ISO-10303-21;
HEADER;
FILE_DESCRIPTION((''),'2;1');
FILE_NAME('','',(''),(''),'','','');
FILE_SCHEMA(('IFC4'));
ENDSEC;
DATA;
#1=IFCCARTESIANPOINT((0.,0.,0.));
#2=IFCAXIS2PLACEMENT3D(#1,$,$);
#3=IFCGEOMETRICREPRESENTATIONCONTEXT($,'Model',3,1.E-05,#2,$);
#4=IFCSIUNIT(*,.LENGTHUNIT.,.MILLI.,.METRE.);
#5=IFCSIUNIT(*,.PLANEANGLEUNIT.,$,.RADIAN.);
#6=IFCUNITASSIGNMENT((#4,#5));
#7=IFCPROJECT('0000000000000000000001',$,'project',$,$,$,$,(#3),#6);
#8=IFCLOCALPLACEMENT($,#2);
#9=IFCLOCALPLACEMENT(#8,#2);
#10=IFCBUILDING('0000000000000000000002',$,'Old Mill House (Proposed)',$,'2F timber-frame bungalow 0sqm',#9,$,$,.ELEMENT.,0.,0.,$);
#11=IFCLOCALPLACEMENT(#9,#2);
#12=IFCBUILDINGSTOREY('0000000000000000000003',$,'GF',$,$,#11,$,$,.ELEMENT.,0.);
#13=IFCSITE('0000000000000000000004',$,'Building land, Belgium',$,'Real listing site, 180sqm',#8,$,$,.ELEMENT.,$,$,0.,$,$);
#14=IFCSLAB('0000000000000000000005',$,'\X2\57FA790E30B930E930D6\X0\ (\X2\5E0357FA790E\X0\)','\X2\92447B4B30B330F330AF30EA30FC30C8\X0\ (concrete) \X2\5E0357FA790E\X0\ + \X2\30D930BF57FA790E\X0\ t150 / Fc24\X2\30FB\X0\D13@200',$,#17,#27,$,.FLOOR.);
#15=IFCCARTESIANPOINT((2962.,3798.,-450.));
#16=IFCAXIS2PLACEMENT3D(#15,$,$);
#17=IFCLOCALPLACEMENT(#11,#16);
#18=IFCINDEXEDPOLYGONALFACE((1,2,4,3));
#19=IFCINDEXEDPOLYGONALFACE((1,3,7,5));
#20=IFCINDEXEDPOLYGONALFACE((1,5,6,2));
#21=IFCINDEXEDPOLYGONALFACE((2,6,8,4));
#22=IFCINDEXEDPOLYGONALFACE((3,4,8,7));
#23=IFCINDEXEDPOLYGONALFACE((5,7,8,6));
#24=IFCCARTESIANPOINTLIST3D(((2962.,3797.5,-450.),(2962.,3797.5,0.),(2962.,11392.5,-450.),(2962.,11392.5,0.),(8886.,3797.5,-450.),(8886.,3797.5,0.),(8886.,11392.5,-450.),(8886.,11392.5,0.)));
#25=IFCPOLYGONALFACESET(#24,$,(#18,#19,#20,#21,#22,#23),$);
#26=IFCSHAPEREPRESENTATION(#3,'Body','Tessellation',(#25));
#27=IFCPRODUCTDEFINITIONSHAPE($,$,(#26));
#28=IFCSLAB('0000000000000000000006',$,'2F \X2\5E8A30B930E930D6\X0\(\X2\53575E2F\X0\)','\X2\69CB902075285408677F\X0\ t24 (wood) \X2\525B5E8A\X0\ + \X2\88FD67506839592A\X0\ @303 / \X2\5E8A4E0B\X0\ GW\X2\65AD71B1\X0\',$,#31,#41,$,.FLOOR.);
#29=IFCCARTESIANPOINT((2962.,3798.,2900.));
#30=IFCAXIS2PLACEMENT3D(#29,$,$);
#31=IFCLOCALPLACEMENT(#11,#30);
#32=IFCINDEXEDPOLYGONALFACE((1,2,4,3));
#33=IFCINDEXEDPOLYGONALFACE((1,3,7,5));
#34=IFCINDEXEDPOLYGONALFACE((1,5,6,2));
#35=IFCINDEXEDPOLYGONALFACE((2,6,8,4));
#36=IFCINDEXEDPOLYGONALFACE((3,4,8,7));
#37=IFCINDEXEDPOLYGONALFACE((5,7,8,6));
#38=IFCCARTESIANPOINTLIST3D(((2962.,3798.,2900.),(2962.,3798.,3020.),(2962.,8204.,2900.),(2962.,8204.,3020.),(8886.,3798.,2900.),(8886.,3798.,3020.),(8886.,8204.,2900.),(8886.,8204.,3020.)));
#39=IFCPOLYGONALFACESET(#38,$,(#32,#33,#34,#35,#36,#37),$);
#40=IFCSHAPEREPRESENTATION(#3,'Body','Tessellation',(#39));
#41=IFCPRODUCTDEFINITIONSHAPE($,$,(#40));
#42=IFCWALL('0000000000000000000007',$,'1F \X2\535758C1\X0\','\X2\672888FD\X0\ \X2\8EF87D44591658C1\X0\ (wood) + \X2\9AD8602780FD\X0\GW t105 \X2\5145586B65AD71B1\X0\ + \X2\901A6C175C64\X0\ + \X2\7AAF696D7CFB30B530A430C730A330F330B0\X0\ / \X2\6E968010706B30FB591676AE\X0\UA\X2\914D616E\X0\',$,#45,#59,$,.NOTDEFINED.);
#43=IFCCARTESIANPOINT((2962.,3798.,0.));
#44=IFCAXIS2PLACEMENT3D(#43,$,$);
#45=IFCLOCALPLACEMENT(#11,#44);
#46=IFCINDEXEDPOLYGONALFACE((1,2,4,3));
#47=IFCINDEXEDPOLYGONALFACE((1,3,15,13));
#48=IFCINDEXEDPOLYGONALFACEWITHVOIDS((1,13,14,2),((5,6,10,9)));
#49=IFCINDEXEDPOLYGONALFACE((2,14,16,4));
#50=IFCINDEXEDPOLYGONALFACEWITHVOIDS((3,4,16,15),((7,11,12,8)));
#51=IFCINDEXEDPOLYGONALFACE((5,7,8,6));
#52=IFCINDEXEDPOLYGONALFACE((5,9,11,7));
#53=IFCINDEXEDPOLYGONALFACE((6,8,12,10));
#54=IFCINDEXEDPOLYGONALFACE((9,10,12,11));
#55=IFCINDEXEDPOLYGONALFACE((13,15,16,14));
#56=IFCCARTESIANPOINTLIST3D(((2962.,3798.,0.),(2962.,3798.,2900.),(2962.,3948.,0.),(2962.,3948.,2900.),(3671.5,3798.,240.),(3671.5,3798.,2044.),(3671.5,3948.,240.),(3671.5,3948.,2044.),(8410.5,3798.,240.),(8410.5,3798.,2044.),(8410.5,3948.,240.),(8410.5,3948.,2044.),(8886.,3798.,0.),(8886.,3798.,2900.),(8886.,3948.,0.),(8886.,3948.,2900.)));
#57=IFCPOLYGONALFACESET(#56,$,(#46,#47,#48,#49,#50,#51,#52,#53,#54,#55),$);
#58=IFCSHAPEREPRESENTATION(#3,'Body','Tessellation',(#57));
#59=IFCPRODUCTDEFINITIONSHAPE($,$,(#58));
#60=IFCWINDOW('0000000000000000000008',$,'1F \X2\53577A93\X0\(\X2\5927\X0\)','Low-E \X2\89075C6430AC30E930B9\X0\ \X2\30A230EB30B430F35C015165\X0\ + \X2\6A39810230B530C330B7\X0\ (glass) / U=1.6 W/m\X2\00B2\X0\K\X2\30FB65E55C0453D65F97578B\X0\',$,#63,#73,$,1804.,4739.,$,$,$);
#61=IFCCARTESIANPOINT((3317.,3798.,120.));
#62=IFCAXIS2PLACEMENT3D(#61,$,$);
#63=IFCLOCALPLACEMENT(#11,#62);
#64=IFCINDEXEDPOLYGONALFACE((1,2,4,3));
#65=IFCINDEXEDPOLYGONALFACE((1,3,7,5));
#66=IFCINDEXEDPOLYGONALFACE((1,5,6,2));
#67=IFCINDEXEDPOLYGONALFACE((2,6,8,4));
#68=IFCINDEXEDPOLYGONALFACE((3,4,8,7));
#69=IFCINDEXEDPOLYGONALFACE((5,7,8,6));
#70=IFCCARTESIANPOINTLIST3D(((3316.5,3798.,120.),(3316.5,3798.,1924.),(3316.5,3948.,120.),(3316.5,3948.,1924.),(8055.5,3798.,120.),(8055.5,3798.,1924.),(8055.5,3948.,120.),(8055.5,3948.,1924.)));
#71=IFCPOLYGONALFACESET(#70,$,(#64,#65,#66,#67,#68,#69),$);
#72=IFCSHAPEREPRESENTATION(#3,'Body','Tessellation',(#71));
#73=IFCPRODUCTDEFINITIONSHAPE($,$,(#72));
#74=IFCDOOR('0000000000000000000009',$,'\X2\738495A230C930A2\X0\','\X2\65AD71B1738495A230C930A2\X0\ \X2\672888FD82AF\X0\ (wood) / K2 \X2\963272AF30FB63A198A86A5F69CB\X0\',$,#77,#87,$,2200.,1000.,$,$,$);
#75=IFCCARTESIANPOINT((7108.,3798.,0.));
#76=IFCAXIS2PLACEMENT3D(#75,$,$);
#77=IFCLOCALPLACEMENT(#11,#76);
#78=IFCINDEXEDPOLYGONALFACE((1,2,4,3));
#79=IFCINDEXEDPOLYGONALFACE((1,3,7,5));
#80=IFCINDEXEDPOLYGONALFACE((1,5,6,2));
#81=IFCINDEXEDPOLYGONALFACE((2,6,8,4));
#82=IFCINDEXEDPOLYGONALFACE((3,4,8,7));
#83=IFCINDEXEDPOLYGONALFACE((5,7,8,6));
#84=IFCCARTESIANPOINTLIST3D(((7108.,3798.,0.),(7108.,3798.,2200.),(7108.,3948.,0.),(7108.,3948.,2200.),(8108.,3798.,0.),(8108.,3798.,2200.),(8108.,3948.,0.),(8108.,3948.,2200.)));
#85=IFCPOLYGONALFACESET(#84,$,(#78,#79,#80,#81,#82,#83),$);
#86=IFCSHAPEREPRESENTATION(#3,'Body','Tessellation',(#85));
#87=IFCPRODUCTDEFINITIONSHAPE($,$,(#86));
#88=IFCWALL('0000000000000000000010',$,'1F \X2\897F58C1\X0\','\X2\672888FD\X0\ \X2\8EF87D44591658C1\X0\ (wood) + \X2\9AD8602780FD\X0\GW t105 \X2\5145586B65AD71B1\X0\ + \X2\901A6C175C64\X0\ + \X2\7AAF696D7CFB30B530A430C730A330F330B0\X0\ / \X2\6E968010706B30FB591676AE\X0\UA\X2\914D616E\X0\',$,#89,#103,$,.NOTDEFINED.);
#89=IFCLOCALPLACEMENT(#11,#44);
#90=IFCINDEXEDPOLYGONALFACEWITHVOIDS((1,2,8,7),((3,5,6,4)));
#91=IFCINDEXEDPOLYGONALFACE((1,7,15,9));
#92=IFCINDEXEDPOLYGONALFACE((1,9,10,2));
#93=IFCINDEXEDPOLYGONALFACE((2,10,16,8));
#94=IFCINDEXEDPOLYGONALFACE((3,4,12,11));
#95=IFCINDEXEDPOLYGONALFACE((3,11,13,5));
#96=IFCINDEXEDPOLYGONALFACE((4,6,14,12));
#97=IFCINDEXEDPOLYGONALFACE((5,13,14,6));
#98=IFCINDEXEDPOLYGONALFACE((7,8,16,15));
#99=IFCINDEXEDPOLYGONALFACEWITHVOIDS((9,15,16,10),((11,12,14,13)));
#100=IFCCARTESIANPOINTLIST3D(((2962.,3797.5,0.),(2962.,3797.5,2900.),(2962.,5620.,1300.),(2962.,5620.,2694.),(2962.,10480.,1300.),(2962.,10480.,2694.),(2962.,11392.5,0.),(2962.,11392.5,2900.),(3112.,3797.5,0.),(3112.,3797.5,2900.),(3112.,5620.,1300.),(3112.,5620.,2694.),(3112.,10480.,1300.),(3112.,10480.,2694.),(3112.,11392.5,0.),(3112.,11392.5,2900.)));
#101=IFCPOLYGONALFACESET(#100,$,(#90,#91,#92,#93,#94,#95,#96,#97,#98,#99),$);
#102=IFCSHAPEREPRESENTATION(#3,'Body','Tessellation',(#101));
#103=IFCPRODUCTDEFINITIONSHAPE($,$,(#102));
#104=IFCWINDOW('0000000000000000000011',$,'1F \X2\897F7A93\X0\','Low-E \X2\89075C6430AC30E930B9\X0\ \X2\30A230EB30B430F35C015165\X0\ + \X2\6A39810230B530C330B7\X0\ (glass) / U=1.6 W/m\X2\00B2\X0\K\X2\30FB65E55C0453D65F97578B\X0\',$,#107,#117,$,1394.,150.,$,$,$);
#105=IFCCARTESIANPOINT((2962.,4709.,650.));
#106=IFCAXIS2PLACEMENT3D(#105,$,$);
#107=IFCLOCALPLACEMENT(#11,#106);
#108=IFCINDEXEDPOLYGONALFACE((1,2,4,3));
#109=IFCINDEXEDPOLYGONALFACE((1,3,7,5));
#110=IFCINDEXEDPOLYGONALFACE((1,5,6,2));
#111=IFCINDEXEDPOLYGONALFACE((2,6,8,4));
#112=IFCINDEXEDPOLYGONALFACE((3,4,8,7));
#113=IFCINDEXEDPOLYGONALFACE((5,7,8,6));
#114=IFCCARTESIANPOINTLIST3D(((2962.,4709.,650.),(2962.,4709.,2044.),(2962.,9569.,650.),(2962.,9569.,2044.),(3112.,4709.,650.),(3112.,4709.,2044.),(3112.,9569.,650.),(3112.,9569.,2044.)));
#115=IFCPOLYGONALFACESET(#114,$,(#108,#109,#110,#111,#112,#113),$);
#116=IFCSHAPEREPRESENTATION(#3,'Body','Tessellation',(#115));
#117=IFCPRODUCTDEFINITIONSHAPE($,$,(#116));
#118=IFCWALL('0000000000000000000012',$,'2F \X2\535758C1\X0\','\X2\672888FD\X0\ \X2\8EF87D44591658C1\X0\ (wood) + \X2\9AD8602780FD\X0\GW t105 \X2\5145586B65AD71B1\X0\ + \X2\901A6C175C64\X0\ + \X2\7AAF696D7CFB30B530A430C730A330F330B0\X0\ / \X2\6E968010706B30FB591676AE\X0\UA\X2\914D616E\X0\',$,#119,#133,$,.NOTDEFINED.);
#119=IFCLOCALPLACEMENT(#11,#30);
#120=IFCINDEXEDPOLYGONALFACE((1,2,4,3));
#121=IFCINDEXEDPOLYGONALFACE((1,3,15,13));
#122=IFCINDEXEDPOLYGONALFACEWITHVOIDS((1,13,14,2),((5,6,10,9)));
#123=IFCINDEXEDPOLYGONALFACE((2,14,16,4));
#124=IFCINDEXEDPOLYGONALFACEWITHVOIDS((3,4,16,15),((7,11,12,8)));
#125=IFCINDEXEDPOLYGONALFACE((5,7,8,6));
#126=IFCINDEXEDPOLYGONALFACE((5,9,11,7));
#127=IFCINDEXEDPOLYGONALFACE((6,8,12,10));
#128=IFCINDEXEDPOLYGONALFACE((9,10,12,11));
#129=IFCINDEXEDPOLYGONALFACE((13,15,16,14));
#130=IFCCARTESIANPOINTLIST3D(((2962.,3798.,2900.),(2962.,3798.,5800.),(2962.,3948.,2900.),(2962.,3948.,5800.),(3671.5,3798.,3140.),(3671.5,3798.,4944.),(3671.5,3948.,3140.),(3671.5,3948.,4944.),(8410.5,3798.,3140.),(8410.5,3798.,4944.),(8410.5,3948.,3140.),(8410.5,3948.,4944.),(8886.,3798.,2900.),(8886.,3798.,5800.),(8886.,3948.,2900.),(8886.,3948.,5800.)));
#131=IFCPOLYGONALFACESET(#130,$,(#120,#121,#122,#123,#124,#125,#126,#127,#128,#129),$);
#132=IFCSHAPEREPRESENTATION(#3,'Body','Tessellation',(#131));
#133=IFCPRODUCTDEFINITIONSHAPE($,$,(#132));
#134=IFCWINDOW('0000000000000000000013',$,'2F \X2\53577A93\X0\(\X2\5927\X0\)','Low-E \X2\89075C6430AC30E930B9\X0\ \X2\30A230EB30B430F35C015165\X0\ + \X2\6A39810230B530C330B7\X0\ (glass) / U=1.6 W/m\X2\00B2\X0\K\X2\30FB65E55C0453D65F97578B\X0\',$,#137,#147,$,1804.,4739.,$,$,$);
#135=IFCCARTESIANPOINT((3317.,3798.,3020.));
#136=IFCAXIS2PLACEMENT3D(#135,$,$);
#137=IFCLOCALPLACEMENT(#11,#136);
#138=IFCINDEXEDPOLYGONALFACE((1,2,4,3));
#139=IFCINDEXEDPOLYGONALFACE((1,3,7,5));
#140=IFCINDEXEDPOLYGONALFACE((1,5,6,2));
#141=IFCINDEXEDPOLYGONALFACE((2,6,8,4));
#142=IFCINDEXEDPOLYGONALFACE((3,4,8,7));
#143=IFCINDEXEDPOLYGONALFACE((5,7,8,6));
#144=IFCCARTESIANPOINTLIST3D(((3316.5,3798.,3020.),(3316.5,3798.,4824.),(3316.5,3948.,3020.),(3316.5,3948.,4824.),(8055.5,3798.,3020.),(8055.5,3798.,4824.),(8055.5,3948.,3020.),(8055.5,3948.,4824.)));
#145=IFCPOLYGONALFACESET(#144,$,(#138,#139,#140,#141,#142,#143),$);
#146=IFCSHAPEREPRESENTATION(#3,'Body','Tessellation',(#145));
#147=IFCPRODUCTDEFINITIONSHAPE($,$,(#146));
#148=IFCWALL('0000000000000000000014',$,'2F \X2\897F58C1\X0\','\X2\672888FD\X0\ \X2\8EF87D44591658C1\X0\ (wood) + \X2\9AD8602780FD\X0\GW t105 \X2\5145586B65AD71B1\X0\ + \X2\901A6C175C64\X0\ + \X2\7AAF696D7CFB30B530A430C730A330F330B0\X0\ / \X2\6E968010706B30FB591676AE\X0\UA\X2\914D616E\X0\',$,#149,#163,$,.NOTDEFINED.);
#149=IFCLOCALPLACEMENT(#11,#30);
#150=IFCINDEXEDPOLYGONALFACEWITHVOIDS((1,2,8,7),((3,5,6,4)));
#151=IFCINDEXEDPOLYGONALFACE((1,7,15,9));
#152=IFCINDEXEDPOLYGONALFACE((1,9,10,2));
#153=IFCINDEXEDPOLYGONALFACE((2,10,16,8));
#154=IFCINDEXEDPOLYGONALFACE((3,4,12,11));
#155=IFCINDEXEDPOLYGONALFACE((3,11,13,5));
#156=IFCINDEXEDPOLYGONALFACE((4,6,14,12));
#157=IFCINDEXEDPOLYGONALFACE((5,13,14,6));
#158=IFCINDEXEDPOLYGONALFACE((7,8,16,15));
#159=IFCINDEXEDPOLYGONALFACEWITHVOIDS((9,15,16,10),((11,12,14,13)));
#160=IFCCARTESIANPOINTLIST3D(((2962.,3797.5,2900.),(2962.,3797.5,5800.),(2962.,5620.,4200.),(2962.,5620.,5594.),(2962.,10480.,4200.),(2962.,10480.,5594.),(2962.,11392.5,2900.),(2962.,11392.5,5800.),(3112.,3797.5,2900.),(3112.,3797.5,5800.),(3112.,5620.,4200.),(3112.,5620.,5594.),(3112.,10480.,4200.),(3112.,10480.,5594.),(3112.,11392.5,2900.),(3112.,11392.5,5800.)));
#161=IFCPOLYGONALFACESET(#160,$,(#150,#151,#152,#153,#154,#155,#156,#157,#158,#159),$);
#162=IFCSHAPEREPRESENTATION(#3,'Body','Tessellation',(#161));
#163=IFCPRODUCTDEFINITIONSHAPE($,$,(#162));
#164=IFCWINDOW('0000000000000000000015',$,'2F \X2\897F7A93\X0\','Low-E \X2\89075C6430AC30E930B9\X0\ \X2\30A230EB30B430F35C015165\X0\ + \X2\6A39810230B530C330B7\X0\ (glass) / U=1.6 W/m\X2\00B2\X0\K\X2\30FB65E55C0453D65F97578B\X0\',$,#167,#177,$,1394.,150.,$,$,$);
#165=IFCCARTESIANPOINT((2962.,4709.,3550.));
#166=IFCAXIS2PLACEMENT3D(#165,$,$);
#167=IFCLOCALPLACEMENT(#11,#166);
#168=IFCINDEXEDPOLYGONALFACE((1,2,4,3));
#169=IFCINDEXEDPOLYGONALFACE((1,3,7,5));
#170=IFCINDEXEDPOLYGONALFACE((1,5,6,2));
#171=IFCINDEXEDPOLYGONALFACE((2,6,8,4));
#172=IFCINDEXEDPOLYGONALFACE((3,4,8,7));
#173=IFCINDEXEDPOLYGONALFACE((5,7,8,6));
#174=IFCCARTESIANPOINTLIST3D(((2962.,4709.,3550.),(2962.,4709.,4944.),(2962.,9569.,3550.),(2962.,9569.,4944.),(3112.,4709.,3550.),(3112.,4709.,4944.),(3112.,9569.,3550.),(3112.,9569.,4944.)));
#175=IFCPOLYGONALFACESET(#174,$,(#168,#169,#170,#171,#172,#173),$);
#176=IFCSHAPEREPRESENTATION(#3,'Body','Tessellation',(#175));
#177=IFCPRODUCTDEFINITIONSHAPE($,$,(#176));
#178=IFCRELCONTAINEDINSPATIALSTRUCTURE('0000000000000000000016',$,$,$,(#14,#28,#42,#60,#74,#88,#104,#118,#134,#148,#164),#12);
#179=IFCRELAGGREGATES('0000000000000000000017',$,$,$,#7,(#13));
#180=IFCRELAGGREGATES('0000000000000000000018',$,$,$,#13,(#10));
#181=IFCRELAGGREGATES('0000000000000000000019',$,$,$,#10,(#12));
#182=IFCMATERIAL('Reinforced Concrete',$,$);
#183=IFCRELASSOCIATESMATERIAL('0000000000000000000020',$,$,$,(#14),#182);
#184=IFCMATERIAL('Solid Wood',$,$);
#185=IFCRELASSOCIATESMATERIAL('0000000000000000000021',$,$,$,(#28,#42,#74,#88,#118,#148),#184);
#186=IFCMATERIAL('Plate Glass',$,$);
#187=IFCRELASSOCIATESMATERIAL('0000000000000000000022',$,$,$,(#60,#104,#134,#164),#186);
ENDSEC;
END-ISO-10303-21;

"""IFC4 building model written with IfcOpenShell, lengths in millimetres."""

from ifc_helpers import new_model, si_unit, frame, frame_2d, origin, place, context, project, spatial, rectangle, extrude, material, element, fill, save


model = new_model("IFC4")

# Units and contexts
model_context = context("Model", 3, precision=1e-05, world=origin())
ifc_project = project(units=[si_unit("LENGTHUNIT", "METRE", prefix="MILLI"), si_unit("PLANEANGLEUNIT", "RADIAN")], contexts=[model_context])

# Site, building, storey
site_placement = place(None, origin())
site = spatial("IfcSite", under=ifc_project, at=site_placement, Name="Building land, Belgium", ObjectType="Real listing site, 180sqm", CompositionType="ELEMENT", RefElevation=0.0)
building_placement = place(site_placement, origin())
building = spatial("IfcBuilding", under=site, at=building_placement, Name="Old Mill House (Proposed)", ObjectType="2F timber-frame bungalow 0sqm", CompositionType="ELEMENT", ElevationOfRefHeight=0.0, ElevationOfTerrain=0.0)
storey_placement = place(building_placement, origin())
storey = spatial("IfcBuildingStorey", under=building, at=storey_placement, Name="GF", CompositionType="ELEMENT", Elevation=0.0)

# Slabs
ifc_material_1 = material(Name="Reinforced Concrete")
slab_1_placement = place(storey_placement, frame((2962.0, 3798.0, -450.0)))
element("IfcSlab", 1, at=slab_1_placement, inside=storey, material=ifc_material_1, Name="基礎スラブ (布基礎)", Description="鉄筋コンクリート (concrete) 布基礎 + ベタ基礎 t150 / Fc24・D13@200", PredefinedType="FLOOR", context=model_context, shape_type="SweptSolid", body=[
    extrude(rectangle(XDim=5924.0, YDim=7595.0, at=frame_2d((2962.0, 3797.0))), frame((2962.0, 3798.0, -450.0)), (0.0, 0.0, 1.0), 450.0),
])
ifc_material_2 = material(Name="Solid Wood")
slab_2_placement = place(storey_placement, frame((2962.0, 3798.0, 2900.0)))
element("IfcSlab", 2, at=slab_2_placement, inside=storey, material=ifc_material_2, Name="2F 床スラブ(南帯)", Description="構造用合板 t24 (wood) 剛床 + 製材根太 @303 / 床下 GW断熱", PredefinedType="FLOOR", context=model_context, shape_type="SweptSolid", body=[
    extrude(rectangle(XDim=5924.0, YDim=4406.0, at=frame_2d((2962.0, 2203.0))), frame((2962.0, 3798.0, 2900.0)), (0.0, 0.0, 1.0), 120.0),
])

# Wall, openings, window, door
wall_1_placement = place(storey_placement, frame((2962.0, 3798.0, 0.0)))
wall_1 = element("IfcWall", 3, at=wall_1_placement, inside=storey, material=ifc_material_2, Name="1F 南壁", Description="木製 軸組外壁 (wood) + 高性能GW t105 充填断熱 + 通気層 + 窯業系サイディング / 準耐火・外皮UA配慮", PredefinedType="NOTDEFINED", context=model_context, shape_type="SweptSolid", body=[
    extrude(rectangle(XDim=5924.0, YDim=150.0, at=frame_2d((2962.0, 75.0))), frame((2962.0, 3798.0, 0.0)), (0.0, 0.0, 1.0), 2900.0),
])
opening_1_placement = place(storey_placement, frame((3317.0, 3798.0, 120.0)))
opening_1 = element("IfcOpeningElement", 4, at=opening_1_placement, cuts=wall_1, PredefinedType="NOTDEFINED", context=model_context, shape_type="SweptSolid", body=[
    extrude(rectangle(XDim=4739.0, YDim=150.0, at=frame_2d((2369.0, 75.0))), frame((3317.0, 3798.0, 120.0)), (0.0, 0.0, 1.0), 1804.0),
])
opening_2_placement = place(storey_placement, frame((7108.0, 3798.0, 0.0)))
opening_2 = element("IfcOpeningElement", 5, at=opening_2_placement, cuts=wall_1, PredefinedType="NOTDEFINED", context=model_context, shape_type="SweptSolid", body=[
    extrude(rectangle(XDim=1000.0, YDim=150.0, at=frame_2d((500.0, 75.0))), frame((7108.0, 3798.0, 0.0)), (0.0, 0.0, 1.0), 2200.0),
])
ifc_material_3 = material(Name="Plate Glass")
window_1_placement = place(storey_placement, frame((3317.0, 3798.0, 120.0)))
window_1 = element("IfcWindow", 6, at=window_1_placement, inside=storey, material=ifc_material_3, Name="1F 南窓(大)", Description="Low-E 複層ガラス アルゴン封入 + 樹脂サッシ (glass) / U=1.6 W/m²K・日射取得型", OverallHeight=1804.0, OverallWidth=4739.0, context=model_context, shape_type="SweptSolid", body=[
    extrude(rectangle(XDim=4739.0, YDim=150.0, at=frame_2d((2369.0, 75.0))), frame((3317.0, 3798.0, 120.0)), (0.0, 0.0, 1.0), 1804.0),
])
fill(opening_1, window_1)
door_placement = place(storey_placement, frame((7108.0, 3798.0, 0.0)))
door = element("IfcDoor", 7, at=door_placement, inside=storey, material=ifc_material_2, Name="玄関ドア", Description="断熱玄関ドア 木製芯 (wood) / K2 防犯・採風機構", OverallHeight=2200.0, OverallWidth=1000.0, context=model_context, shape_type="SweptSolid", body=[
    extrude(rectangle(XDim=1000.0, YDim=150.0, at=frame_2d((500.0, 75.0))), frame((7108.0, 3798.0, 0.0)), (0.0, 0.0, 1.0), 2200.0),
])
fill(opening_2, door)

# Wall, opening, window
wall_2_placement = place(storey_placement, frame((2962.0, 3798.0, 0.0)))
wall_2 = element("IfcWall", 8, at=wall_2_placement, inside=storey, material=ifc_material_2, Name="1F 西壁", Description="木製 軸組外壁 (wood) + 高性能GW t105 充填断熱 + 通気層 + 窯業系サイディング / 準耐火・外皮UA配慮", PredefinedType="NOTDEFINED", context=model_context, shape_type="SweptSolid", body=[
    extrude(rectangle(XDim=150.0, YDim=7595.0, at=frame_2d((75.0, 3797.0))), frame((2962.0, 3798.0, 0.0)), (0.0, 0.0, 1.0), 2900.0),
])
opening_3_placement = place(storey_placement, frame((2962.0, 4709.0, 650.0)))
opening_3 = element("IfcOpeningElement", 9, at=opening_3_placement, cuts=wall_2, PredefinedType="NOTDEFINED", context=model_context, shape_type="SweptSolid", body=[
    extrude(rectangle(XDim=150.0, YDim=4860.0, at=frame_2d((75.0, 2430.0))), frame((2962.0, 4709.0, 650.0)), (0.0, 0.0, 1.0), 1394.0),
])
window_2_placement = place(storey_placement, frame((2962.0, 4709.0, 650.0)))
window_2 = element("IfcWindow", 10, at=window_2_placement, inside=storey, material=ifc_material_3, Name="1F 西窓", Description="Low-E 複層ガラス アルゴン封入 + 樹脂サッシ (glass) / U=1.6 W/m²K・日射取得型", OverallHeight=1394.0, OverallWidth=150.0, context=model_context, shape_type="SweptSolid", body=[
    extrude(rectangle(XDim=150.0, YDim=4860.0, at=frame_2d((75.0, 2430.0))), frame((2962.0, 4709.0, 650.0)), (0.0, 0.0, 1.0), 1394.0),
])
fill(opening_3, window_2)

# Walls, openings, windows
wall_3_placement = place(storey_placement, frame((2962.0, 3798.0, 2900.0)))
wall_3 = element("IfcWall", 11, at=wall_3_placement, inside=storey, material=ifc_material_2, Name="2F 南壁", Description="木製 軸組外壁 (wood) + 高性能GW t105 充填断熱 + 通気層 + 窯業系サイディング / 準耐火・外皮UA配慮", PredefinedType="NOTDEFINED", context=model_context, shape_type="SweptSolid", body=[
    extrude(rectangle(XDim=5924.0, YDim=150.0, at=frame_2d((2962.0, 75.0))), frame((2962.0, 3798.0, 2900.0)), (0.0, 0.0, 1.0), 2900.0),
])
opening_4_placement = place(storey_placement, frame((3317.0, 3798.0, 3020.0)))
opening_4 = element("IfcOpeningElement", 12, at=opening_4_placement, cuts=wall_3, PredefinedType="NOTDEFINED", context=model_context, shape_type="SweptSolid", body=[
    extrude(rectangle(XDim=4739.0, YDim=150.0, at=frame_2d((2369.0, 75.0))), frame((3317.0, 3798.0, 3020.0)), (0.0, 0.0, 1.0), 1804.0),
])
window_3_placement = place(storey_placement, frame((3317.0, 3798.0, 3020.0)))
window_3 = element("IfcWindow", 13, at=window_3_placement, inside=storey, material=ifc_material_3, Name="2F 南窓(大)", Description="Low-E 複層ガラス アルゴン封入 + 樹脂サッシ (glass) / U=1.6 W/m²K・日射取得型", OverallHeight=1804.0, OverallWidth=4739.0, context=model_context, shape_type="SweptSolid", body=[
    extrude(rectangle(XDim=4739.0, YDim=150.0, at=frame_2d((2369.0, 75.0))), frame((3317.0, 3798.0, 3020.0)), (0.0, 0.0, 1.0), 1804.0),
])
fill(opening_4, window_3)
wall_4_placement = place(storey_placement, frame((2962.0, 3798.0, 2900.0)))
wall_4 = element("IfcWall", 14, at=wall_4_placement, inside=storey, material=ifc_material_2, Name="2F 西壁", Description="木製 軸組外壁 (wood) + 高性能GW t105 充填断熱 + 通気層 + 窯業系サイディング / 準耐火・外皮UA配慮", PredefinedType="NOTDEFINED", context=model_context, shape_type="SweptSolid", body=[
    extrude(rectangle(XDim=150.0, YDim=7595.0, at=frame_2d((75.0, 3797.0))), frame((2962.0, 3798.0, 2900.0)), (0.0, 0.0, 1.0), 2900.0),
])
opening_5_placement = place(storey_placement, frame((2962.0, 4709.0, 3550.0)))
opening_5 = element("IfcOpeningElement", 15, at=opening_5_placement, cuts=wall_4, PredefinedType="NOTDEFINED", context=model_context, shape_type="SweptSolid", body=[
    extrude(rectangle(XDim=150.0, YDim=4860.0, at=frame_2d((75.0, 2430.0))), frame((2962.0, 4709.0, 3550.0)), (0.0, 0.0, 1.0), 1394.0),
])
window_4_placement = place(storey_placement, frame((2962.0, 4709.0, 3550.0)))
window_4 = element("IfcWindow", 16, at=window_4_placement, inside=storey, material=ifc_material_3, Name="2F 西窓", Description="Low-E 複層ガラス アルゴン封入 + 樹脂サッシ (glass) / U=1.6 W/m²K・日射取得型", OverallHeight=1394.0, OverallWidth=150.0, context=model_context, shape_type="SweptSolid", body=[
    extrude(rectangle(XDim=150.0, YDim=4860.0, at=frame_2d((75.0, 2430.0))), frame((2962.0, 4709.0, 3550.0)), (0.0, 0.0, 1.0), 1394.0),
])
fill(opening_5, window_4)

save(model, "model.ifc")
